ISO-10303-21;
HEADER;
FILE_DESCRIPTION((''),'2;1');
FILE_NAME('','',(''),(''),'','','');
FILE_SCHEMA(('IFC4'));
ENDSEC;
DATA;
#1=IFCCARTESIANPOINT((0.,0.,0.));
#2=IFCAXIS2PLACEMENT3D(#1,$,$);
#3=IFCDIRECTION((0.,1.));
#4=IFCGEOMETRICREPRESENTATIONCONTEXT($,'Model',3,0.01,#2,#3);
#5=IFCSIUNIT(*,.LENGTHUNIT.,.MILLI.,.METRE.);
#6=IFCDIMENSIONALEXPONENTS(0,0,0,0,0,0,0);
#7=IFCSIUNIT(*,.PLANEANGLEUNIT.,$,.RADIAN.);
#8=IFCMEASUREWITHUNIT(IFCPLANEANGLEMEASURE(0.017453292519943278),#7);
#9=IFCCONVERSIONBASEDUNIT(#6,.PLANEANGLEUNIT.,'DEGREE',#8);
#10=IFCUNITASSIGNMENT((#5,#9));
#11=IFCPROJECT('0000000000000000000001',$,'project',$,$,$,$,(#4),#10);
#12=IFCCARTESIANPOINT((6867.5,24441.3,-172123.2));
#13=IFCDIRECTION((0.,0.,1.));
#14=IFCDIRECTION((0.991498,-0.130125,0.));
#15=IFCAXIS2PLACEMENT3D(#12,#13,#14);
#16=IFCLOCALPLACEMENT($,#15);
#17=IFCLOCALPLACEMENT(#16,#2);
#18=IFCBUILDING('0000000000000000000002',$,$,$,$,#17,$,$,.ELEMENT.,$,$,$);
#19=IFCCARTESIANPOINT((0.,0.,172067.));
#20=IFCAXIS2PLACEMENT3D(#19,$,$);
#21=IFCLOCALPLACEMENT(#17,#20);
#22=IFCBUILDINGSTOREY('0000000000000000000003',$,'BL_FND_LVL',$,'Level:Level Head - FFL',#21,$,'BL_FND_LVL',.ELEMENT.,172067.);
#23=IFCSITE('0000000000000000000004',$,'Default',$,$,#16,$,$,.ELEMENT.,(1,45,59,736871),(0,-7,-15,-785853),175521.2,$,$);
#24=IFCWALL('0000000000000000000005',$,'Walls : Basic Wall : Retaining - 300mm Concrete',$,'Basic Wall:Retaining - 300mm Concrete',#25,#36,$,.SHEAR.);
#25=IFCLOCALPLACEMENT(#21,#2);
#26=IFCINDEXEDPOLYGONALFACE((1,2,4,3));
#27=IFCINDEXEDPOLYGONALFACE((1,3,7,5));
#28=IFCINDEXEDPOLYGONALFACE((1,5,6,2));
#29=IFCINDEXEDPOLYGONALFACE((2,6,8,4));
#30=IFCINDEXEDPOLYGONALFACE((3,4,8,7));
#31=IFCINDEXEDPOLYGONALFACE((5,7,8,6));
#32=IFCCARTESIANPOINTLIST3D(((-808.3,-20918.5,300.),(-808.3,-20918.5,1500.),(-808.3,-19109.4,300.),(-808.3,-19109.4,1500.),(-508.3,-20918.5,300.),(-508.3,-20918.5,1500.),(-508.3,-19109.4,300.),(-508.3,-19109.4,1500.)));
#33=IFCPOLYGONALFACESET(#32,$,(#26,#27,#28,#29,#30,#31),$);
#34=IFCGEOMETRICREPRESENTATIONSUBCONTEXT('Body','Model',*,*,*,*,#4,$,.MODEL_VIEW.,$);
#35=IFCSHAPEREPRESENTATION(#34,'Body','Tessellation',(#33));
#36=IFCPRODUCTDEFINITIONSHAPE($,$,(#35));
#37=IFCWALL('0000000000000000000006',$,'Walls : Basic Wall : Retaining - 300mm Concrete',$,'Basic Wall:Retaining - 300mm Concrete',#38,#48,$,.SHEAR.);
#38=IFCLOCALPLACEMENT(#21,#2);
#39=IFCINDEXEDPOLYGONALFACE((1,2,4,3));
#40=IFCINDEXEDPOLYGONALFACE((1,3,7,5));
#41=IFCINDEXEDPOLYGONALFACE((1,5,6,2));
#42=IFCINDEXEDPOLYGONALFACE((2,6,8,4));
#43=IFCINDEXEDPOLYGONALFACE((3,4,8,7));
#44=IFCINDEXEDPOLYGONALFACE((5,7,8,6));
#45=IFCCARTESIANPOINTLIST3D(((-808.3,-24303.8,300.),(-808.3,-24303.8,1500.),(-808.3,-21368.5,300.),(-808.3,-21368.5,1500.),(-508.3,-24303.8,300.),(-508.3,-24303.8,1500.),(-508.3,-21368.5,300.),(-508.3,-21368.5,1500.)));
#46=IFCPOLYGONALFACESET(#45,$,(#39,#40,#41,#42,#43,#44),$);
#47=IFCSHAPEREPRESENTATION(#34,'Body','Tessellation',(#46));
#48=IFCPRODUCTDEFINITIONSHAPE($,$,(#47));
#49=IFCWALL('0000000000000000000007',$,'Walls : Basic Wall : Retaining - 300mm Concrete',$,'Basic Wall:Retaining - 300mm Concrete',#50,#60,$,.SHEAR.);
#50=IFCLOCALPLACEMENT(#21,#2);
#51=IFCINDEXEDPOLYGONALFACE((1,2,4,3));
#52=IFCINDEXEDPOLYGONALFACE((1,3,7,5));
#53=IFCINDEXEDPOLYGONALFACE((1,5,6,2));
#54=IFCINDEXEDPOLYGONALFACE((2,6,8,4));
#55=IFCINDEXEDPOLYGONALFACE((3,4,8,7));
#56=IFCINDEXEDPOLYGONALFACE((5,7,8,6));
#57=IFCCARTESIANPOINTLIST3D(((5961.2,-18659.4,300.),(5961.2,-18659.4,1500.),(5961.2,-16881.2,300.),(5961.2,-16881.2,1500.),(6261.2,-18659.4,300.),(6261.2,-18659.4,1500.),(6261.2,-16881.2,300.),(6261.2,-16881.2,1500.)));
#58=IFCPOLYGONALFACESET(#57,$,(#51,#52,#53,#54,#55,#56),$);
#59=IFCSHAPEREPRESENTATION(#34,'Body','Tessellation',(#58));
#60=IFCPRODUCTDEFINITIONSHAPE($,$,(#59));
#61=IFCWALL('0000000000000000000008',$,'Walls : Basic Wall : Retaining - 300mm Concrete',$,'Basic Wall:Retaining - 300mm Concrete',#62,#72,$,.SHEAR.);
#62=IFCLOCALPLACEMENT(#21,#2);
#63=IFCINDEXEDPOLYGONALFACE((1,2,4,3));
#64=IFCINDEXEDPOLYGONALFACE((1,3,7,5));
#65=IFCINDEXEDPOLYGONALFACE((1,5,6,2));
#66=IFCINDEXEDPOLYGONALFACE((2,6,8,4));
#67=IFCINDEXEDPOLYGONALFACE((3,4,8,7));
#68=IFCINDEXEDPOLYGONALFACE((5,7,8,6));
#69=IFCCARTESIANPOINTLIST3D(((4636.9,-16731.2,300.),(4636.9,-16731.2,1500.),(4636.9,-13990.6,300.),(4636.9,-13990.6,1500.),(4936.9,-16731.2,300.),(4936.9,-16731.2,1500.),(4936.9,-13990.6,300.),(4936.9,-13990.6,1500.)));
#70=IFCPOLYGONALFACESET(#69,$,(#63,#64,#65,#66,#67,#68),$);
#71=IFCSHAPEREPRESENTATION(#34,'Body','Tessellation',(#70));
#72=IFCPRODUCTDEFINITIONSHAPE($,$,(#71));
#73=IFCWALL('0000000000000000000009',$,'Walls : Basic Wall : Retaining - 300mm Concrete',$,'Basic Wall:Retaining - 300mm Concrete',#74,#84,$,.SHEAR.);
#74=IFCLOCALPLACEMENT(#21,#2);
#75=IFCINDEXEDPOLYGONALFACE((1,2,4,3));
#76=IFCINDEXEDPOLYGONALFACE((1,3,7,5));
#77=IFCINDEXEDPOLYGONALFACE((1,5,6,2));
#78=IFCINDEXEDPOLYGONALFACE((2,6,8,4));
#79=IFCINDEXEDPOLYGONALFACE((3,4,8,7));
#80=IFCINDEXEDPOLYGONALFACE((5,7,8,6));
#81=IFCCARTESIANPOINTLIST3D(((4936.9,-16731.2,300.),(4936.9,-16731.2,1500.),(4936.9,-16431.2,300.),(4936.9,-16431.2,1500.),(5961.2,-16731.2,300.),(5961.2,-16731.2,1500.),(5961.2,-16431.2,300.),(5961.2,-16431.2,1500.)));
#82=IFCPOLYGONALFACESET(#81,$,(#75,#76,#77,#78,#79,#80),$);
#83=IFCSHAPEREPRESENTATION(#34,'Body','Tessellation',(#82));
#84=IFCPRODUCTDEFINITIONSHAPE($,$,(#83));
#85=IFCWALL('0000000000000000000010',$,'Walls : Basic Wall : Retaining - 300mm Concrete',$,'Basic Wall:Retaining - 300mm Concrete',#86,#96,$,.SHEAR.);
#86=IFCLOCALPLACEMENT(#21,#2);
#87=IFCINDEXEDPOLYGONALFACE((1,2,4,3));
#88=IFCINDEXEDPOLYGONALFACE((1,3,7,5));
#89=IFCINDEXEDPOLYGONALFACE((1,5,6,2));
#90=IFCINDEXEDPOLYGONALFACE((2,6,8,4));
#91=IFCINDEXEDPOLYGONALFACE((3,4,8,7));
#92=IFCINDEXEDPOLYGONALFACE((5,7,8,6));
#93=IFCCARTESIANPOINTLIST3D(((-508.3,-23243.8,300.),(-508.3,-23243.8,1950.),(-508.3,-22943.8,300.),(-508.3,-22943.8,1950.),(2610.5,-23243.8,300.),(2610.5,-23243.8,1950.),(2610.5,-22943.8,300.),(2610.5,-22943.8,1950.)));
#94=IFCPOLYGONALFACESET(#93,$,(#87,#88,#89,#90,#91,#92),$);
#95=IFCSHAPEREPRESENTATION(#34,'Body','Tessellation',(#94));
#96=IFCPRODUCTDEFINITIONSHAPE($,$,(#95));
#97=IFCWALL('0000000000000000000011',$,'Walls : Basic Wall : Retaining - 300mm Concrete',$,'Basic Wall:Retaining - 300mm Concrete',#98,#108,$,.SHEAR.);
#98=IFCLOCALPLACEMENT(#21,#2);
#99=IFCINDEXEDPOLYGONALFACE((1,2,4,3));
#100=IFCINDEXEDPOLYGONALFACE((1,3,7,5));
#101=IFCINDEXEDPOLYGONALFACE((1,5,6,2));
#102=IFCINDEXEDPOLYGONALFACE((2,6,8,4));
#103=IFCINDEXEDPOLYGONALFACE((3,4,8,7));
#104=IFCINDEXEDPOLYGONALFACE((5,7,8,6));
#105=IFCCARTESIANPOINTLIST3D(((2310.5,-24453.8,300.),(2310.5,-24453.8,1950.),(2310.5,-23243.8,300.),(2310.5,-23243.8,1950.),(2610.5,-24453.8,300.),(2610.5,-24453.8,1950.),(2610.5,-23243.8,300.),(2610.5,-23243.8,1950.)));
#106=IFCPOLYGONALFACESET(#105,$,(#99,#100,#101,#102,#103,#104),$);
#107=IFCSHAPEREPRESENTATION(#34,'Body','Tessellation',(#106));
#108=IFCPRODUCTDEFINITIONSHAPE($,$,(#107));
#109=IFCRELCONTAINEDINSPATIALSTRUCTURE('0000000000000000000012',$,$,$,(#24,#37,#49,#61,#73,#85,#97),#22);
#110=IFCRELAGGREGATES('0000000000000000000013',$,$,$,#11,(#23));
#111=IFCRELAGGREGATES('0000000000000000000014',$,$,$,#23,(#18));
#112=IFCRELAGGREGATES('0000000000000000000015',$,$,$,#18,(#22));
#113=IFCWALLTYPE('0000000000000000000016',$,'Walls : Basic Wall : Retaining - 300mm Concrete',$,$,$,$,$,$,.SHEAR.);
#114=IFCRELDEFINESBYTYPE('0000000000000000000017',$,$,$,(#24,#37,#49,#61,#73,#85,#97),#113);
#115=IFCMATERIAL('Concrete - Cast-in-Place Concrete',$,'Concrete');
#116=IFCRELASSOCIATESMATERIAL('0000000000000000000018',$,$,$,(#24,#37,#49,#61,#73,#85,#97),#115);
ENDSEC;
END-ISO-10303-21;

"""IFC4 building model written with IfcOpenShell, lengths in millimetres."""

from ifc_helpers import new_model, entity, si_unit, converted_unit, direction, frame, origin, place, context, subcontext, project, spatial, indexed_curve, outline, extrude, material, type_object, element, save


model = new_model("IFC4")

# Units and contexts
model_context = context("Model", 3, precision=0.01, world=origin(), true_north=direction((0.0, 1.0)))
body_context = subcontext(model_context, "Body", "Model", "MODEL_VIEW")
ifc_project = project(units=[si_unit("LENGTHUNIT", "METRE", prefix="MILLI"), converted_unit("PLANEANGLEUNIT", "DEGREE", entity("IfcPlaneAngleMeasure", 0.017453292519943278), si_unit("PLANEANGLEUNIT", "RADIAN"), dimensions=[0, 0, 0, 0, 0, 0, 0])], contexts=[model_context])

# Site, building, storey
site_placement = place(None, frame((6867.5, 24441.3, -172123.2), z_axis=(0.0, 0.0, 1.0), x_axis=(0.991498, -0.130125, 0.0)))
site = spatial("IfcSite", under=ifc_project, at=site_placement, Name="Default", CompositionType="ELEMENT", RefLatitude=(1, 45, 59, 736871), RefLongitude=(0, -7, -15, -785853), RefElevation=175521.2)
building_placement = place(site_placement, origin())
building = spatial("IfcBuilding", under=site, at=building_placement, CompositionType="ELEMENT")
storey_placement = place(building_placement, frame((0.0, 0.0, 172067.0)))
storey = spatial("IfcBuildingStorey", under=building, at=storey_placement, Name="BL_FND_LVL", ObjectType="Level:Level Head - FFL", LongName="BL_FND_LVL", CompositionType="ELEMENT", Elevation=172067.0)

# Shared definitions
ifc_material_1 = material(Name="Concrete - Cast-in-Place Concrete", Category="Concrete")

# Walls
wall_type = type_object("IfcWallType", Name="Walls : Basic Wall : Retaining - 300mm Concrete", PredefinedType="SHEAR")
wall_1_placement = place(storey_placement, frame((-658.3, -19109.4, 300.0), z_axis=(0.0, 0.0, 1.0), x_axis=(0.0, -1.0, 0.0)))
element("IfcWall", 1, at=wall_1_placement, inside=storey, type_object=wall_type, material=ifc_material_1, Name="Walls : Basic Wall : Retaining - 300mm Concrete", ObjectType="Basic Wall:Retaining - 300mm Concrete", PredefinedType="SHEAR", context=body_context, shape_type="SweptSolid", body=[
    extrude(outline(indexed_curve([(1809.1, 150.0), (0.0, 150.0), (0.0, -150.0), (1809.1, -150.0), (1809.1, 150.0)], self_intersect=False)), origin(), (0.0, 0.0, 1.0), 1200.0),
])
wall_2_placement = place(storey_placement, frame((-658.3, -21368.5, 300.0), z_axis=(0.0, 0.0, 1.0), x_axis=(0.0, -1.0, 0.0)))
element("IfcWall", 2, at=wall_2_placement, inside=storey, type_object=wall_type, material=ifc_material_1, Name="Walls : Basic Wall : Retaining - 300mm Concrete", ObjectType="Basic Wall:Retaining - 300mm Concrete", PredefinedType="SHEAR", context=body_context, shape_type="SweptSolid", body=[
    extrude(outline(indexed_curve([(2935.3, 150.0), (0.0, 150.0), (0.0, -150.0), (2935.3, -150.0), (2935.3, 150.0)], self_intersect=False)), origin(), (0.0, 0.0, 1.0), 1200.0),
])
wall_3_placement = place(storey_placement, frame((6111.2, -16881.2, 300.0), z_axis=(0.0, 0.0, 1.0), x_axis=(0.0, -1.0, 0.0)))
element("IfcWall", 3, at=wall_3_placement, inside=storey, type_object=wall_type, material=ifc_material_1, Name="Walls : Basic Wall : Retaining - 300mm Concrete", ObjectType="Basic Wall:Retaining - 300mm Concrete", PredefinedType="SHEAR", context=body_context, shape_type="SweptSolid", body=[
    extrude(outline(indexed_curve([(1778.2, 150.0), (0.0, 150.0), (0.0, -150.0), (1778.2, -150.0), (1778.2, 150.0)], self_intersect=False)), origin(), (0.0, 0.0, 1.0), 1200.0),
])
wall_4_placement = place(storey_placement, frame((4786.9, -13990.6, 300.0), z_axis=(0.0, 0.0, 1.0), x_axis=(0.0, -1.0, 0.0)))
element("IfcWall", 4, at=wall_4_placement, inside=storey, type_object=wall_type, material=ifc_material_1, Name="Walls : Basic Wall : Retaining - 300mm Concrete", ObjectType="Basic Wall:Retaining - 300mm Concrete", PredefinedType="SHEAR", context=body_context, shape_type="SweptSolid", body=[
    extrude(outline(indexed_curve([(2740.6, 150.0), (0.0, 150.0), (0.0, -150.0), (2740.6, -150.0), (2740.6, 150.0)], self_intersect=False)), origin(), (0.0, 0.0, 1.0), 1200.0),
])
wall_5_placement = place(storey_placement, frame((4936.9, -16581.2, 300.0)))
element("IfcWall", 5, at=wall_5_placement, inside=storey, type_object=wall_type, material=ifc_material_1, Name="Walls : Basic Wall : Retaining - 300mm Concrete", ObjectType="Basic Wall:Retaining - 300mm Concrete", PredefinedType="SHEAR", context=body_context, shape_type="SweptSolid", body=[
    extrude(outline(indexed_curve([(1024.3, 150.0), (0.0, 150.0), (0.0, -150.0), (1024.3, -150.0), (1024.3, 150.0)], self_intersect=False)), origin(), (0.0, 0.0, 1.0), 1200.0),
])
wall_6_placement = place(storey_placement, frame((-508.3, -23093.8, 300.0)))
element("IfcWall", 6, at=wall_6_placement, inside=storey, type_object=wall_type, material=ifc_material_1, Name="Walls : Basic Wall : Retaining - 300mm Concrete", ObjectType="Basic Wall:Retaining - 300mm Concrete", PredefinedType="SHEAR", context=body_context, shape_type="SweptSolid", body=[
    extrude(outline(indexed_curve([(3118.8, 150.0), (0.0, 150.0), (0.0, -150.0), (3118.8, -150.0), (3118.8, 150.0)], self_intersect=False)), origin(), (0.0, 0.0, 1.0), 1650.0),
])
wall_7_placement = place(storey_placement, frame((2460.5, -23243.8, 300.0), z_axis=(0.0, 0.0, 1.0), x_axis=(0.0, -1.0, 0.0)))
element("IfcWall", 7, at=wall_7_placement, inside=storey, type_object=wall_type, material=ifc_material_1, Name="Walls : Basic Wall : Retaining - 300mm Concrete", ObjectType="Basic Wall:Retaining - 300mm Concrete", PredefinedType="SHEAR", context=body_context, shape_type="SweptSolid", body=[
    extrude(outline(indexed_curve([(1210.0, 150.0), (0.0, 150.0), (0.0, -150.0), (1210.0, -150.0), (1210.0, 150.0)], self_intersect=False)), origin(), (0.0, 0.0, 1.0), 1650.0),
])

save(model, "model.ifc")
